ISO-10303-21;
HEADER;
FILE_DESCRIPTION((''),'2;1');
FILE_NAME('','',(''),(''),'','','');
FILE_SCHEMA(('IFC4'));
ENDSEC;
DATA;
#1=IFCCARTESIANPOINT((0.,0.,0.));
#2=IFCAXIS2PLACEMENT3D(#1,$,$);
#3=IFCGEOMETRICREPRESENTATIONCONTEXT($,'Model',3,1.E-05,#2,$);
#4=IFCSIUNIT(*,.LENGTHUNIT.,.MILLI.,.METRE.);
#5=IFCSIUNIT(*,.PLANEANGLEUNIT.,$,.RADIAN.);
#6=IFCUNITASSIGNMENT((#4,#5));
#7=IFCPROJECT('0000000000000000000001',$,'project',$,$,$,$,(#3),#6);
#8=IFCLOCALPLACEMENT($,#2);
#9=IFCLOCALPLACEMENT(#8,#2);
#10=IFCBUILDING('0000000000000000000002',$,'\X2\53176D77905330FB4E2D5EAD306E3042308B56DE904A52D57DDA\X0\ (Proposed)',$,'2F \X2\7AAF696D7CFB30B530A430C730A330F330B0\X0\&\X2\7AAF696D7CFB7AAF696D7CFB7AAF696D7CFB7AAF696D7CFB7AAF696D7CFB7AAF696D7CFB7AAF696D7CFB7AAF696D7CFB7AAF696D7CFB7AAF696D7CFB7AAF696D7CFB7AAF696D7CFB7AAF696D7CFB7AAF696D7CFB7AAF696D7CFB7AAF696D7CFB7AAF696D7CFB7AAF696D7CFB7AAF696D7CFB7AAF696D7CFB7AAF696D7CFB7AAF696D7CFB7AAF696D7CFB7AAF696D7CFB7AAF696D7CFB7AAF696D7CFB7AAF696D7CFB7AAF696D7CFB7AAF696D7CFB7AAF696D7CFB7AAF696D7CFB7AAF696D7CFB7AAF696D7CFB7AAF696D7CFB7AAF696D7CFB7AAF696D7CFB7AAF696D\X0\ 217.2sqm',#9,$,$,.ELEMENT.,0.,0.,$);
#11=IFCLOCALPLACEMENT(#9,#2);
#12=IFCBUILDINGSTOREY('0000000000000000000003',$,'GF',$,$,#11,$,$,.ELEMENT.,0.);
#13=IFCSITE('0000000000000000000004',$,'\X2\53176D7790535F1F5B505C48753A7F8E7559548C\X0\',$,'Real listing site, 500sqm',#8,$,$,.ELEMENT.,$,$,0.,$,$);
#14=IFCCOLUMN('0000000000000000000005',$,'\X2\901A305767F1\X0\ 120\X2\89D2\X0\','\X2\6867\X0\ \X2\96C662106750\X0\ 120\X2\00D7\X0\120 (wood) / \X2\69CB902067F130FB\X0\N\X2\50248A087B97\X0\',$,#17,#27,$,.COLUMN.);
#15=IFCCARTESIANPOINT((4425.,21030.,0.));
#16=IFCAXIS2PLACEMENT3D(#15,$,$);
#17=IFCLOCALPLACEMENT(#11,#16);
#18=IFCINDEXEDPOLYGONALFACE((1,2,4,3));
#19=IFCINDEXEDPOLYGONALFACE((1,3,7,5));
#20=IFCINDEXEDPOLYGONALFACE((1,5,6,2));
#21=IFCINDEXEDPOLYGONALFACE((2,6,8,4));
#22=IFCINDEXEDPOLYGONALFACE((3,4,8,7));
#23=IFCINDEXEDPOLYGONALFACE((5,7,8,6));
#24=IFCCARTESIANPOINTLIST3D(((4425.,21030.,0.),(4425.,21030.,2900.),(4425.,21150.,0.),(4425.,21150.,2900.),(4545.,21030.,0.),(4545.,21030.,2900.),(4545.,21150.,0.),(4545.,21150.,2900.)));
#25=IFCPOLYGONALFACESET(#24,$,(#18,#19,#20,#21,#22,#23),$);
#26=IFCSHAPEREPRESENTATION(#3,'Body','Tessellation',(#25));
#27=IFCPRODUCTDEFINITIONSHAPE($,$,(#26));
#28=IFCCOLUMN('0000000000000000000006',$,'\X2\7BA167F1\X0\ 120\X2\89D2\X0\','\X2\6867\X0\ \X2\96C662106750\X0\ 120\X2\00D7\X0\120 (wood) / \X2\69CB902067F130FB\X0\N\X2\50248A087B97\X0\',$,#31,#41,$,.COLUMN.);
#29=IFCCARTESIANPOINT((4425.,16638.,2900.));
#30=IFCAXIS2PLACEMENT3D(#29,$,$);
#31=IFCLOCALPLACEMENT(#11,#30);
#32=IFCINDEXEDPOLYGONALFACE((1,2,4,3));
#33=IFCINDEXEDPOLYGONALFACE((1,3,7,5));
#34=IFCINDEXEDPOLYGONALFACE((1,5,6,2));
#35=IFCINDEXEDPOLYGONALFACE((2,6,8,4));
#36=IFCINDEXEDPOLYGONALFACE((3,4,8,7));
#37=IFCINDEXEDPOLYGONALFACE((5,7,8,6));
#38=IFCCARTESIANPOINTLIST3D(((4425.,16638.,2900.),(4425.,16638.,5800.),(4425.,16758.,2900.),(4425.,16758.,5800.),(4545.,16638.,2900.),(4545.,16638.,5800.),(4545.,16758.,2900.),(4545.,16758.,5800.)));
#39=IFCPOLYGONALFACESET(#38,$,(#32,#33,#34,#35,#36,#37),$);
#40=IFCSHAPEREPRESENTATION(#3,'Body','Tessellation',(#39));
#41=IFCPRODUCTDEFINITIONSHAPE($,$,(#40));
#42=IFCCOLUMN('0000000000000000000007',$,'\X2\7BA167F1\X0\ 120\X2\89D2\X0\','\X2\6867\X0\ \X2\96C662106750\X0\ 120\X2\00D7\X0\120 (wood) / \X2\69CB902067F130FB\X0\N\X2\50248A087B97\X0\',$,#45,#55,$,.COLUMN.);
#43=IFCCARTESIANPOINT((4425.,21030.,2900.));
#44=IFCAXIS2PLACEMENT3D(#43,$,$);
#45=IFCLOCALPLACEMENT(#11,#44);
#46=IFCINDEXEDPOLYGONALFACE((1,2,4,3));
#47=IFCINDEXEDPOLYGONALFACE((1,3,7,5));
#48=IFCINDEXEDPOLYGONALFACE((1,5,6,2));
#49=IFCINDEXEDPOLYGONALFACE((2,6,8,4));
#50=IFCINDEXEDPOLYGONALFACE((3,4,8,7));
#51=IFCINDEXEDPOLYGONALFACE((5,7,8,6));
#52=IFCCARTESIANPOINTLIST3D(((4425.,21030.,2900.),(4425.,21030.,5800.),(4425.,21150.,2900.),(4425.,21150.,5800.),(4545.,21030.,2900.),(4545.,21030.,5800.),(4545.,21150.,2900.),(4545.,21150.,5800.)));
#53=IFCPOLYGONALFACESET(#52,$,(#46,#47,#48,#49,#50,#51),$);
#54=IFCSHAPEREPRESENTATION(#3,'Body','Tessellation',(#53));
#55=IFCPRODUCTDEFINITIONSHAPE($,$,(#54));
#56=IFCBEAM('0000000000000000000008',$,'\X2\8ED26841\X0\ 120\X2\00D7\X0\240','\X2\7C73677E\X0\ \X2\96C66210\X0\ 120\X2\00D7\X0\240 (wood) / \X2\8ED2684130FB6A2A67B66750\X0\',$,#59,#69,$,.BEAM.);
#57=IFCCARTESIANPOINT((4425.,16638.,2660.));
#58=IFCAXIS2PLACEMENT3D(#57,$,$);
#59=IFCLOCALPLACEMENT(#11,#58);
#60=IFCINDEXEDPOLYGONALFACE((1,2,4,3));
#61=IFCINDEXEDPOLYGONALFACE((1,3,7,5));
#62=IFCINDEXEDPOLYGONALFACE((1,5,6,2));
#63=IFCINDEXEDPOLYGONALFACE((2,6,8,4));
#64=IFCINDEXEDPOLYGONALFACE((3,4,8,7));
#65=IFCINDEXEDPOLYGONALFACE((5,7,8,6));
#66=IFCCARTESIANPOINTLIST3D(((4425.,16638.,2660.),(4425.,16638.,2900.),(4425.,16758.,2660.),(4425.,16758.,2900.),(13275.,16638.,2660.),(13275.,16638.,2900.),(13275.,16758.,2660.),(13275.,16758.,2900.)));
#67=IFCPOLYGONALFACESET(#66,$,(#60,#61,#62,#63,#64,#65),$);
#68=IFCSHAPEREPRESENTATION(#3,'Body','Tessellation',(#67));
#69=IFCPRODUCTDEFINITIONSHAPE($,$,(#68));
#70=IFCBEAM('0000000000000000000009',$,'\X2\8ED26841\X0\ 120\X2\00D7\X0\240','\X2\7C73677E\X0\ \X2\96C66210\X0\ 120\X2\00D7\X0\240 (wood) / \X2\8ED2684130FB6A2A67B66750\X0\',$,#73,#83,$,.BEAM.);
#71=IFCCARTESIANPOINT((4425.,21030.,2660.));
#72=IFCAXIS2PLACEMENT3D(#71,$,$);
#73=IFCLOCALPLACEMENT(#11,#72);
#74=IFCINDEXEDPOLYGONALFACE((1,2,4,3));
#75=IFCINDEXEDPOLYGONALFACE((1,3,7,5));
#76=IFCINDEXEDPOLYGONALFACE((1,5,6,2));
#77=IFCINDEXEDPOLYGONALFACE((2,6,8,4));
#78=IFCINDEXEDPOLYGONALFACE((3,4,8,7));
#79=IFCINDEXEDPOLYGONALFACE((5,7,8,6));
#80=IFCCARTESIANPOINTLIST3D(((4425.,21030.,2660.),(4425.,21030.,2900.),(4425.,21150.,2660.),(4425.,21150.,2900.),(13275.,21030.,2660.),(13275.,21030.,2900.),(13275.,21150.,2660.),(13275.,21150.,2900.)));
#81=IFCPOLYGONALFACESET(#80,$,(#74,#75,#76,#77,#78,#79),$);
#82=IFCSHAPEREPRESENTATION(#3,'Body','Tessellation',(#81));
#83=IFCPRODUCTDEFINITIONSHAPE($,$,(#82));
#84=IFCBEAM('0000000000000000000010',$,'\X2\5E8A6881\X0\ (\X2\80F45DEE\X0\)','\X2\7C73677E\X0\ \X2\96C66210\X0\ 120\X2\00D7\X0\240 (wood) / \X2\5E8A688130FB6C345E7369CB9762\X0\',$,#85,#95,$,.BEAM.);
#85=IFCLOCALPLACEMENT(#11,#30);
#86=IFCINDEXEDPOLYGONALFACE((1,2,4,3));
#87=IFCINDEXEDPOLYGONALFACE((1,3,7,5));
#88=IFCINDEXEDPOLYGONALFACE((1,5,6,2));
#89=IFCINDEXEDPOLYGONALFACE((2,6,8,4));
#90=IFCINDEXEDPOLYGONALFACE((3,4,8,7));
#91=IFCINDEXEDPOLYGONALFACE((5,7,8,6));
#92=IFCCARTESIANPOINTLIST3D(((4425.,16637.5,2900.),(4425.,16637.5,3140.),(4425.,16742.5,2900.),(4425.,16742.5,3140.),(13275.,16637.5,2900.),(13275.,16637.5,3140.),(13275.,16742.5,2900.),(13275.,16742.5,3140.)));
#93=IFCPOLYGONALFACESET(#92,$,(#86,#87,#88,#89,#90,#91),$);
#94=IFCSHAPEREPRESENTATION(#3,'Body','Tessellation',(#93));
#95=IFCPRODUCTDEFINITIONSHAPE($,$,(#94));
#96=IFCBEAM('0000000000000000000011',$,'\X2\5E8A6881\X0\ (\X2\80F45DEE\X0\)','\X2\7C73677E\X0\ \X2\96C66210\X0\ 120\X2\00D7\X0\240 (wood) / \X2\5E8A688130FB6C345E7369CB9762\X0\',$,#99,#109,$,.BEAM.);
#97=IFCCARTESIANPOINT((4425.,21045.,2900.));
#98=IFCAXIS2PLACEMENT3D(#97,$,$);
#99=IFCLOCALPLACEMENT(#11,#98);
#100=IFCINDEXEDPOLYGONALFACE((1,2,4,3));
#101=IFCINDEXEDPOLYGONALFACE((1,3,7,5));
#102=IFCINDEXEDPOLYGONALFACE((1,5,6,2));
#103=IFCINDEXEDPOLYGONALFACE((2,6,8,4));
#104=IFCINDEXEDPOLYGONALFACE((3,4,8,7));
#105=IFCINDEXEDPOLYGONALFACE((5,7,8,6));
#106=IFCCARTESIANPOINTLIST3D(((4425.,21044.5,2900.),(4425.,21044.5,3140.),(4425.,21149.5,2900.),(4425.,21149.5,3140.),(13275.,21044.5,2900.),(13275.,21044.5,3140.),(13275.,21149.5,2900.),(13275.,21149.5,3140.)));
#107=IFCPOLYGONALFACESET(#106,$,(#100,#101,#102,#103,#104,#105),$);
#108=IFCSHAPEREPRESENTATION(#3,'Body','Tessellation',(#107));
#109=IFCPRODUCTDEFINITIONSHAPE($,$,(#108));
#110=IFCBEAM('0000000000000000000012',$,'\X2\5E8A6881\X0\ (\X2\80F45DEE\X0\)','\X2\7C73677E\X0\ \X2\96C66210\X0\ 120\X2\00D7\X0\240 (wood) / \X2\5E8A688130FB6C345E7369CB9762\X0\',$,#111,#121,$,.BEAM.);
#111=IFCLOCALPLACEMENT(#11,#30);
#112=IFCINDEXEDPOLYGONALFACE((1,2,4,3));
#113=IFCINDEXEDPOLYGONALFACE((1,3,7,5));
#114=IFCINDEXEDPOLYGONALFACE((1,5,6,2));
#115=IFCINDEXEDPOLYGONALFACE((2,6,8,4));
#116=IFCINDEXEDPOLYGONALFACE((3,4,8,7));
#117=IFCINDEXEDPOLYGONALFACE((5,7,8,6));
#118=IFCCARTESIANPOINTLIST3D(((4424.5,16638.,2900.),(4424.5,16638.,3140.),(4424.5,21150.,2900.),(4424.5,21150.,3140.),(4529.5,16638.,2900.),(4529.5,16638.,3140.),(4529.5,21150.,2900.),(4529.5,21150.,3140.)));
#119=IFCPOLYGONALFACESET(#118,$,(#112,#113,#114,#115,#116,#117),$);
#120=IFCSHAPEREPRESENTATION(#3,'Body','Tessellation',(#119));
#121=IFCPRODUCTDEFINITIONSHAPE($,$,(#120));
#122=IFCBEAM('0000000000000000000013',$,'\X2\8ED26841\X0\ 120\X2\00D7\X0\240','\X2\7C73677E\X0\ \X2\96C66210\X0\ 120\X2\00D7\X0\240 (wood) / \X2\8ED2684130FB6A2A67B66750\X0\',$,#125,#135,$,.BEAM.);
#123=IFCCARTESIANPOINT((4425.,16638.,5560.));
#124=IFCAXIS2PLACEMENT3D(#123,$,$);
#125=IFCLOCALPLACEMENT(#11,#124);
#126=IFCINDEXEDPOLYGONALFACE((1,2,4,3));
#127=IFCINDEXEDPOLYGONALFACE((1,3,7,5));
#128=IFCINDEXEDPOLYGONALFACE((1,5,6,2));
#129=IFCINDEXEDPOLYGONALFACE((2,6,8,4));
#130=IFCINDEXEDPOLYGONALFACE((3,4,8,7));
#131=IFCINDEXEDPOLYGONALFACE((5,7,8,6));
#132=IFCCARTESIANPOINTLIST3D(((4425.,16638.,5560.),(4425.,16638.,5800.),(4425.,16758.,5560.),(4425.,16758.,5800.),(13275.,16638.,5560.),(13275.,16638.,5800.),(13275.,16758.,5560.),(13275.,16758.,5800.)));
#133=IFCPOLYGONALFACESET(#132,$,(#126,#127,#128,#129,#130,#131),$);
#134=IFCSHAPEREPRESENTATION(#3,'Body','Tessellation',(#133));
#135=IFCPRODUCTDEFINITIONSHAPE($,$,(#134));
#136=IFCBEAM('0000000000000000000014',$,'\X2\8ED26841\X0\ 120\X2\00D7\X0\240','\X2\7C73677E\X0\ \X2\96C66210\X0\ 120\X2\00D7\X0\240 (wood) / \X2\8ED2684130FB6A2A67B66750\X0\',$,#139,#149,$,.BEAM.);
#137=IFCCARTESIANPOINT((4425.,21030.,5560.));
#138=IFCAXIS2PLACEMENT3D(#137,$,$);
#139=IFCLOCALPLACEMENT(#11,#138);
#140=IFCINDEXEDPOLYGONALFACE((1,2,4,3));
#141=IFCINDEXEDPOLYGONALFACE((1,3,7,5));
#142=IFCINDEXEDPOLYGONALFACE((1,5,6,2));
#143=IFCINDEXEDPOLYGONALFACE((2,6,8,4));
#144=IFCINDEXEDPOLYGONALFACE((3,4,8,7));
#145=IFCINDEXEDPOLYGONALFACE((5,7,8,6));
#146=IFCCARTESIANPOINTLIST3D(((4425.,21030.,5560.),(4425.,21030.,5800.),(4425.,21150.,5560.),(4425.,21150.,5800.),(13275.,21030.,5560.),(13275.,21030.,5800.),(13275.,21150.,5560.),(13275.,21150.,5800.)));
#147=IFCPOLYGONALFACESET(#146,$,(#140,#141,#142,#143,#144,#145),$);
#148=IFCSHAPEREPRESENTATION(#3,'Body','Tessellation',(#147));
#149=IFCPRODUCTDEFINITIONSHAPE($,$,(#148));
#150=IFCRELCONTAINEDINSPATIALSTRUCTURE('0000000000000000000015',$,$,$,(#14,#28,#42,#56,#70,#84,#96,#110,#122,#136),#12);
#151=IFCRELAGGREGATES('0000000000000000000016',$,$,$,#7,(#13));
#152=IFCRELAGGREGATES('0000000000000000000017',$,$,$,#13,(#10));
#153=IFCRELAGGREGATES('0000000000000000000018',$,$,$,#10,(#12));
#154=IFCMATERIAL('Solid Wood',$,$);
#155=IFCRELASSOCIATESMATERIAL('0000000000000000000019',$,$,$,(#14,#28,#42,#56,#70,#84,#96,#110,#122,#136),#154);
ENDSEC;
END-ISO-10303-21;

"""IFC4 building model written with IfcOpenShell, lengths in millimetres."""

from ifc_helpers import new_model, si_unit, frame, frame_2d, origin, place, context, project, spatial, rectangle, extrude, material, element, save


model = new_model("IFC4")

# Units and contexts
model_context = context("Model", 3, precision=1e-05, world=origin())
ifc_project = project(units=[si_unit("LENGTHUNIT", "METRE", prefix="MILLI"), si_unit("PLANEANGLEUNIT", "RADIAN")], contexts=[model_context])

# Site, building, storey
site_placement = place(None, origin())
site = spatial("IfcSite", under=ifc_project, at=site_placement, Name="北海道弟子屈町美留和", ObjectType="Real listing site, 500sqm", CompositionType="ELEMENT", RefElevation=0.0)
building_placement = place(site_placement, origin())
building = spatial("IfcBuilding", under=site, at=building_placement, Name="北海道・中庭のある回遊動線 (Proposed)", ObjectType="2F 窯業系サイディング&窯業系窯業系窯業系窯業系窯業系窯業系窯業系窯業系窯業系窯業系窯業系窯業系窯業系窯業系窯業系窯業系窯業系窯業系窯業系窯業系窯業系窯業系窯業系窯業系窯業系窯業系窯業系窯業系窯業系窯業系窯業系窯業系窯業系窯業系窯業系窯業系窯業 217.2sqm", CompositionType="ELEMENT", ElevationOfRefHeight=0.0, ElevationOfTerrain=0.0)
storey_placement = place(building_placement, origin())
storey = spatial("IfcBuildingStorey", under=building, at=storey_placement, Name="GF", CompositionType="ELEMENT", Elevation=0.0)

# Columns
ifc_material_1 = material(Name="Solid Wood")
column_1_placement = place(storey_placement, frame((4425.0, 21030.0, 0.0)))
element("IfcColumn", 1, at=column_1_placement, inside=storey, material=ifc_material_1, Name="通し柱 120角", Description="桧 集成材 120×120 (wood) / 構造柱・N値計算", PredefinedType="COLUMN", context=model_context, shape_type="SweptSolid", body=[
    extrude(rectangle(XDim=120.0, YDim=120.0, at=frame_2d((60.0, 60.0))), frame((4425.0, 21030.0, 0.0)), (0.0, 0.0, 1.0), 2900.0),
])
column_2_placement = place(storey_placement, frame((4425.0, 16638.0, 2900.0)))
element("IfcColumn", 2, at=column_2_placement, inside=storey, material=ifc_material_1, Name="管柱 120角", Description="桧 集成材 120×120 (wood) / 構造柱・N値計算", PredefinedType="COLUMN", context=model_context, shape_type="SweptSolid", body=[
    extrude(rectangle(XDim=120.0, YDim=120.0, at=frame_2d((60.0, 60.0))), frame((4425.0, 16638.0, 2900.0)), (0.0, 0.0, 1.0), 2900.0),
])
column_3_placement = place(storey_placement, frame((4425.0, 21030.0, 2900.0)))
element("IfcColumn", 3, at=column_3_placement, inside=storey, material=ifc_material_1, Name="管柱 120角", Description="桧 集成材 120×120 (wood) / 構造柱・N値計算", PredefinedType="COLUMN", context=model_context, shape_type="SweptSolid", body=[
    extrude(rectangle(XDim=120.0, YDim=120.0, at=frame_2d((60.0, 60.0))), frame((4425.0, 21030.0, 2900.0)), (0.0, 0.0, 1.0), 2900.0),
])

# Beams
beam_1_placement = place(storey_placement, frame((4425.0, 16638.0, 2660.0)))
element("IfcBeam", 4, at=beam_1_placement, inside=storey, material=ifc_material_1, Name="軒桁 120×240", Description="米松 集成 120×240 (wood) / 軒桁・横架材", PredefinedType="BEAM", context=model_context, shape_type="SweptSolid", body=[
    extrude(rectangle(XDim=8850.0, YDim=120.0, at=frame_2d((4425.0, 60.0))), frame((4425.0, 16638.0, 2660.0)), (0.0, 0.0, 1.0), 240.0),
])
beam_2_placement = place(storey_placement, frame((4425.0, 21030.0, 2660.0)))
element("IfcBeam", 5, at=beam_2_placement, inside=storey, material=ifc_material_1, Name="軒桁 120×240", Description="米松 集成 120×240 (wood) / 軒桁・横架材", PredefinedType="BEAM", context=model_context, shape_type="SweptSolid", body=[
    extrude(rectangle(XDim=8850.0, YDim=120.0, at=frame_2d((4425.0, 60.0))), frame((4425.0, 21030.0, 2660.0)), (0.0, 0.0, 1.0), 240.0),
])
beam_3_placement = place(storey_placement, frame((4425.0, 16638.0, 2900.0)))
element("IfcBeam", 6, at=beam_3_placement, inside=storey, material=ifc_material_1, Name="床梁 (胴差)", Description="米松 集成 120×240 (wood) / 床梁・水平構面", PredefinedType="BEAM", context=model_context, shape_type="SweptSolid", body=[
    extrude(rectangle(XDim=8850.0, YDim=105.0, at=frame_2d((4425.0, 52.0))), frame((4425.0, 16638.0, 2900.0)), (0.0, 0.0, 1.0), 240.0),
])
beam_4_placement = place(storey_placement, frame((4425.0, 21045.0, 2900.0)))
element("IfcBeam", 7, at=beam_4_placement, inside=storey, material=ifc_material_1, Name="床梁 (胴差)", Description="米松 集成 120×240 (wood) / 床梁・水平構面", PredefinedType="BEAM", context=model_context, shape_type="SweptSolid", body=[
    extrude(rectangle(XDim=8850.0, YDim=105.0, at=frame_2d((4425.0, 52.0))), frame((4425.0, 21045.0, 2900.0)), (0.0, 0.0, 1.0), 240.0),
])
beam_5_placement = place(storey_placement, frame((4425.0, 16638.0, 2900.0)))
element("IfcBeam", 8, at=beam_5_placement, inside=storey, material=ifc_material_1, Name="床梁 (胴差)", Description="米松 集成 120×240 (wood) / 床梁・水平構面", PredefinedType="BEAM", context=model_context, shape_type="SweptSolid", body=[
    extrude(rectangle(XDim=105.0, YDim=4512.0, at=frame_2d((52.0, 2256.0))), frame((4425.0, 16638.0, 2900.0)), (0.0, 0.0, 1.0), 240.0),
])
beam_6_placement = place(storey_placement, frame((4425.0, 16638.0, 5560.0)))
element("IfcBeam", 9, at=beam_6_placement, inside=storey, material=ifc_material_1, Name="軒桁 120×240", Description="米松 集成 120×240 (wood) / 軒桁・横架材", PredefinedType="BEAM", context=model_context, shape_type="SweptSolid", body=[
    extrude(rectangle(XDim=8850.0, YDim=120.0, at=frame_2d((4425.0, 60.0))), frame((4425.0, 16638.0, 5560.0)), (0.0, 0.0, 1.0), 240.0),
])
beam_7_placement = place(storey_placement, frame((4425.0, 21030.0, 5560.0)))
element("IfcBeam", 10, at=beam_7_placement, inside=storey, material=ifc_material_1, Name="軒桁 120×240", Description="米松 集成 120×240 (wood) / 軒桁・横架材", PredefinedType="BEAM", context=model_context, shape_type="SweptSolid", body=[
    extrude(rectangle(XDim=8850.0, YDim=120.0, at=frame_2d((4425.0, 60.0))), frame((4425.0, 21030.0, 5560.0)), (0.0, 0.0, 1.0), 240.0),
])

save(model, "model.ifc")
